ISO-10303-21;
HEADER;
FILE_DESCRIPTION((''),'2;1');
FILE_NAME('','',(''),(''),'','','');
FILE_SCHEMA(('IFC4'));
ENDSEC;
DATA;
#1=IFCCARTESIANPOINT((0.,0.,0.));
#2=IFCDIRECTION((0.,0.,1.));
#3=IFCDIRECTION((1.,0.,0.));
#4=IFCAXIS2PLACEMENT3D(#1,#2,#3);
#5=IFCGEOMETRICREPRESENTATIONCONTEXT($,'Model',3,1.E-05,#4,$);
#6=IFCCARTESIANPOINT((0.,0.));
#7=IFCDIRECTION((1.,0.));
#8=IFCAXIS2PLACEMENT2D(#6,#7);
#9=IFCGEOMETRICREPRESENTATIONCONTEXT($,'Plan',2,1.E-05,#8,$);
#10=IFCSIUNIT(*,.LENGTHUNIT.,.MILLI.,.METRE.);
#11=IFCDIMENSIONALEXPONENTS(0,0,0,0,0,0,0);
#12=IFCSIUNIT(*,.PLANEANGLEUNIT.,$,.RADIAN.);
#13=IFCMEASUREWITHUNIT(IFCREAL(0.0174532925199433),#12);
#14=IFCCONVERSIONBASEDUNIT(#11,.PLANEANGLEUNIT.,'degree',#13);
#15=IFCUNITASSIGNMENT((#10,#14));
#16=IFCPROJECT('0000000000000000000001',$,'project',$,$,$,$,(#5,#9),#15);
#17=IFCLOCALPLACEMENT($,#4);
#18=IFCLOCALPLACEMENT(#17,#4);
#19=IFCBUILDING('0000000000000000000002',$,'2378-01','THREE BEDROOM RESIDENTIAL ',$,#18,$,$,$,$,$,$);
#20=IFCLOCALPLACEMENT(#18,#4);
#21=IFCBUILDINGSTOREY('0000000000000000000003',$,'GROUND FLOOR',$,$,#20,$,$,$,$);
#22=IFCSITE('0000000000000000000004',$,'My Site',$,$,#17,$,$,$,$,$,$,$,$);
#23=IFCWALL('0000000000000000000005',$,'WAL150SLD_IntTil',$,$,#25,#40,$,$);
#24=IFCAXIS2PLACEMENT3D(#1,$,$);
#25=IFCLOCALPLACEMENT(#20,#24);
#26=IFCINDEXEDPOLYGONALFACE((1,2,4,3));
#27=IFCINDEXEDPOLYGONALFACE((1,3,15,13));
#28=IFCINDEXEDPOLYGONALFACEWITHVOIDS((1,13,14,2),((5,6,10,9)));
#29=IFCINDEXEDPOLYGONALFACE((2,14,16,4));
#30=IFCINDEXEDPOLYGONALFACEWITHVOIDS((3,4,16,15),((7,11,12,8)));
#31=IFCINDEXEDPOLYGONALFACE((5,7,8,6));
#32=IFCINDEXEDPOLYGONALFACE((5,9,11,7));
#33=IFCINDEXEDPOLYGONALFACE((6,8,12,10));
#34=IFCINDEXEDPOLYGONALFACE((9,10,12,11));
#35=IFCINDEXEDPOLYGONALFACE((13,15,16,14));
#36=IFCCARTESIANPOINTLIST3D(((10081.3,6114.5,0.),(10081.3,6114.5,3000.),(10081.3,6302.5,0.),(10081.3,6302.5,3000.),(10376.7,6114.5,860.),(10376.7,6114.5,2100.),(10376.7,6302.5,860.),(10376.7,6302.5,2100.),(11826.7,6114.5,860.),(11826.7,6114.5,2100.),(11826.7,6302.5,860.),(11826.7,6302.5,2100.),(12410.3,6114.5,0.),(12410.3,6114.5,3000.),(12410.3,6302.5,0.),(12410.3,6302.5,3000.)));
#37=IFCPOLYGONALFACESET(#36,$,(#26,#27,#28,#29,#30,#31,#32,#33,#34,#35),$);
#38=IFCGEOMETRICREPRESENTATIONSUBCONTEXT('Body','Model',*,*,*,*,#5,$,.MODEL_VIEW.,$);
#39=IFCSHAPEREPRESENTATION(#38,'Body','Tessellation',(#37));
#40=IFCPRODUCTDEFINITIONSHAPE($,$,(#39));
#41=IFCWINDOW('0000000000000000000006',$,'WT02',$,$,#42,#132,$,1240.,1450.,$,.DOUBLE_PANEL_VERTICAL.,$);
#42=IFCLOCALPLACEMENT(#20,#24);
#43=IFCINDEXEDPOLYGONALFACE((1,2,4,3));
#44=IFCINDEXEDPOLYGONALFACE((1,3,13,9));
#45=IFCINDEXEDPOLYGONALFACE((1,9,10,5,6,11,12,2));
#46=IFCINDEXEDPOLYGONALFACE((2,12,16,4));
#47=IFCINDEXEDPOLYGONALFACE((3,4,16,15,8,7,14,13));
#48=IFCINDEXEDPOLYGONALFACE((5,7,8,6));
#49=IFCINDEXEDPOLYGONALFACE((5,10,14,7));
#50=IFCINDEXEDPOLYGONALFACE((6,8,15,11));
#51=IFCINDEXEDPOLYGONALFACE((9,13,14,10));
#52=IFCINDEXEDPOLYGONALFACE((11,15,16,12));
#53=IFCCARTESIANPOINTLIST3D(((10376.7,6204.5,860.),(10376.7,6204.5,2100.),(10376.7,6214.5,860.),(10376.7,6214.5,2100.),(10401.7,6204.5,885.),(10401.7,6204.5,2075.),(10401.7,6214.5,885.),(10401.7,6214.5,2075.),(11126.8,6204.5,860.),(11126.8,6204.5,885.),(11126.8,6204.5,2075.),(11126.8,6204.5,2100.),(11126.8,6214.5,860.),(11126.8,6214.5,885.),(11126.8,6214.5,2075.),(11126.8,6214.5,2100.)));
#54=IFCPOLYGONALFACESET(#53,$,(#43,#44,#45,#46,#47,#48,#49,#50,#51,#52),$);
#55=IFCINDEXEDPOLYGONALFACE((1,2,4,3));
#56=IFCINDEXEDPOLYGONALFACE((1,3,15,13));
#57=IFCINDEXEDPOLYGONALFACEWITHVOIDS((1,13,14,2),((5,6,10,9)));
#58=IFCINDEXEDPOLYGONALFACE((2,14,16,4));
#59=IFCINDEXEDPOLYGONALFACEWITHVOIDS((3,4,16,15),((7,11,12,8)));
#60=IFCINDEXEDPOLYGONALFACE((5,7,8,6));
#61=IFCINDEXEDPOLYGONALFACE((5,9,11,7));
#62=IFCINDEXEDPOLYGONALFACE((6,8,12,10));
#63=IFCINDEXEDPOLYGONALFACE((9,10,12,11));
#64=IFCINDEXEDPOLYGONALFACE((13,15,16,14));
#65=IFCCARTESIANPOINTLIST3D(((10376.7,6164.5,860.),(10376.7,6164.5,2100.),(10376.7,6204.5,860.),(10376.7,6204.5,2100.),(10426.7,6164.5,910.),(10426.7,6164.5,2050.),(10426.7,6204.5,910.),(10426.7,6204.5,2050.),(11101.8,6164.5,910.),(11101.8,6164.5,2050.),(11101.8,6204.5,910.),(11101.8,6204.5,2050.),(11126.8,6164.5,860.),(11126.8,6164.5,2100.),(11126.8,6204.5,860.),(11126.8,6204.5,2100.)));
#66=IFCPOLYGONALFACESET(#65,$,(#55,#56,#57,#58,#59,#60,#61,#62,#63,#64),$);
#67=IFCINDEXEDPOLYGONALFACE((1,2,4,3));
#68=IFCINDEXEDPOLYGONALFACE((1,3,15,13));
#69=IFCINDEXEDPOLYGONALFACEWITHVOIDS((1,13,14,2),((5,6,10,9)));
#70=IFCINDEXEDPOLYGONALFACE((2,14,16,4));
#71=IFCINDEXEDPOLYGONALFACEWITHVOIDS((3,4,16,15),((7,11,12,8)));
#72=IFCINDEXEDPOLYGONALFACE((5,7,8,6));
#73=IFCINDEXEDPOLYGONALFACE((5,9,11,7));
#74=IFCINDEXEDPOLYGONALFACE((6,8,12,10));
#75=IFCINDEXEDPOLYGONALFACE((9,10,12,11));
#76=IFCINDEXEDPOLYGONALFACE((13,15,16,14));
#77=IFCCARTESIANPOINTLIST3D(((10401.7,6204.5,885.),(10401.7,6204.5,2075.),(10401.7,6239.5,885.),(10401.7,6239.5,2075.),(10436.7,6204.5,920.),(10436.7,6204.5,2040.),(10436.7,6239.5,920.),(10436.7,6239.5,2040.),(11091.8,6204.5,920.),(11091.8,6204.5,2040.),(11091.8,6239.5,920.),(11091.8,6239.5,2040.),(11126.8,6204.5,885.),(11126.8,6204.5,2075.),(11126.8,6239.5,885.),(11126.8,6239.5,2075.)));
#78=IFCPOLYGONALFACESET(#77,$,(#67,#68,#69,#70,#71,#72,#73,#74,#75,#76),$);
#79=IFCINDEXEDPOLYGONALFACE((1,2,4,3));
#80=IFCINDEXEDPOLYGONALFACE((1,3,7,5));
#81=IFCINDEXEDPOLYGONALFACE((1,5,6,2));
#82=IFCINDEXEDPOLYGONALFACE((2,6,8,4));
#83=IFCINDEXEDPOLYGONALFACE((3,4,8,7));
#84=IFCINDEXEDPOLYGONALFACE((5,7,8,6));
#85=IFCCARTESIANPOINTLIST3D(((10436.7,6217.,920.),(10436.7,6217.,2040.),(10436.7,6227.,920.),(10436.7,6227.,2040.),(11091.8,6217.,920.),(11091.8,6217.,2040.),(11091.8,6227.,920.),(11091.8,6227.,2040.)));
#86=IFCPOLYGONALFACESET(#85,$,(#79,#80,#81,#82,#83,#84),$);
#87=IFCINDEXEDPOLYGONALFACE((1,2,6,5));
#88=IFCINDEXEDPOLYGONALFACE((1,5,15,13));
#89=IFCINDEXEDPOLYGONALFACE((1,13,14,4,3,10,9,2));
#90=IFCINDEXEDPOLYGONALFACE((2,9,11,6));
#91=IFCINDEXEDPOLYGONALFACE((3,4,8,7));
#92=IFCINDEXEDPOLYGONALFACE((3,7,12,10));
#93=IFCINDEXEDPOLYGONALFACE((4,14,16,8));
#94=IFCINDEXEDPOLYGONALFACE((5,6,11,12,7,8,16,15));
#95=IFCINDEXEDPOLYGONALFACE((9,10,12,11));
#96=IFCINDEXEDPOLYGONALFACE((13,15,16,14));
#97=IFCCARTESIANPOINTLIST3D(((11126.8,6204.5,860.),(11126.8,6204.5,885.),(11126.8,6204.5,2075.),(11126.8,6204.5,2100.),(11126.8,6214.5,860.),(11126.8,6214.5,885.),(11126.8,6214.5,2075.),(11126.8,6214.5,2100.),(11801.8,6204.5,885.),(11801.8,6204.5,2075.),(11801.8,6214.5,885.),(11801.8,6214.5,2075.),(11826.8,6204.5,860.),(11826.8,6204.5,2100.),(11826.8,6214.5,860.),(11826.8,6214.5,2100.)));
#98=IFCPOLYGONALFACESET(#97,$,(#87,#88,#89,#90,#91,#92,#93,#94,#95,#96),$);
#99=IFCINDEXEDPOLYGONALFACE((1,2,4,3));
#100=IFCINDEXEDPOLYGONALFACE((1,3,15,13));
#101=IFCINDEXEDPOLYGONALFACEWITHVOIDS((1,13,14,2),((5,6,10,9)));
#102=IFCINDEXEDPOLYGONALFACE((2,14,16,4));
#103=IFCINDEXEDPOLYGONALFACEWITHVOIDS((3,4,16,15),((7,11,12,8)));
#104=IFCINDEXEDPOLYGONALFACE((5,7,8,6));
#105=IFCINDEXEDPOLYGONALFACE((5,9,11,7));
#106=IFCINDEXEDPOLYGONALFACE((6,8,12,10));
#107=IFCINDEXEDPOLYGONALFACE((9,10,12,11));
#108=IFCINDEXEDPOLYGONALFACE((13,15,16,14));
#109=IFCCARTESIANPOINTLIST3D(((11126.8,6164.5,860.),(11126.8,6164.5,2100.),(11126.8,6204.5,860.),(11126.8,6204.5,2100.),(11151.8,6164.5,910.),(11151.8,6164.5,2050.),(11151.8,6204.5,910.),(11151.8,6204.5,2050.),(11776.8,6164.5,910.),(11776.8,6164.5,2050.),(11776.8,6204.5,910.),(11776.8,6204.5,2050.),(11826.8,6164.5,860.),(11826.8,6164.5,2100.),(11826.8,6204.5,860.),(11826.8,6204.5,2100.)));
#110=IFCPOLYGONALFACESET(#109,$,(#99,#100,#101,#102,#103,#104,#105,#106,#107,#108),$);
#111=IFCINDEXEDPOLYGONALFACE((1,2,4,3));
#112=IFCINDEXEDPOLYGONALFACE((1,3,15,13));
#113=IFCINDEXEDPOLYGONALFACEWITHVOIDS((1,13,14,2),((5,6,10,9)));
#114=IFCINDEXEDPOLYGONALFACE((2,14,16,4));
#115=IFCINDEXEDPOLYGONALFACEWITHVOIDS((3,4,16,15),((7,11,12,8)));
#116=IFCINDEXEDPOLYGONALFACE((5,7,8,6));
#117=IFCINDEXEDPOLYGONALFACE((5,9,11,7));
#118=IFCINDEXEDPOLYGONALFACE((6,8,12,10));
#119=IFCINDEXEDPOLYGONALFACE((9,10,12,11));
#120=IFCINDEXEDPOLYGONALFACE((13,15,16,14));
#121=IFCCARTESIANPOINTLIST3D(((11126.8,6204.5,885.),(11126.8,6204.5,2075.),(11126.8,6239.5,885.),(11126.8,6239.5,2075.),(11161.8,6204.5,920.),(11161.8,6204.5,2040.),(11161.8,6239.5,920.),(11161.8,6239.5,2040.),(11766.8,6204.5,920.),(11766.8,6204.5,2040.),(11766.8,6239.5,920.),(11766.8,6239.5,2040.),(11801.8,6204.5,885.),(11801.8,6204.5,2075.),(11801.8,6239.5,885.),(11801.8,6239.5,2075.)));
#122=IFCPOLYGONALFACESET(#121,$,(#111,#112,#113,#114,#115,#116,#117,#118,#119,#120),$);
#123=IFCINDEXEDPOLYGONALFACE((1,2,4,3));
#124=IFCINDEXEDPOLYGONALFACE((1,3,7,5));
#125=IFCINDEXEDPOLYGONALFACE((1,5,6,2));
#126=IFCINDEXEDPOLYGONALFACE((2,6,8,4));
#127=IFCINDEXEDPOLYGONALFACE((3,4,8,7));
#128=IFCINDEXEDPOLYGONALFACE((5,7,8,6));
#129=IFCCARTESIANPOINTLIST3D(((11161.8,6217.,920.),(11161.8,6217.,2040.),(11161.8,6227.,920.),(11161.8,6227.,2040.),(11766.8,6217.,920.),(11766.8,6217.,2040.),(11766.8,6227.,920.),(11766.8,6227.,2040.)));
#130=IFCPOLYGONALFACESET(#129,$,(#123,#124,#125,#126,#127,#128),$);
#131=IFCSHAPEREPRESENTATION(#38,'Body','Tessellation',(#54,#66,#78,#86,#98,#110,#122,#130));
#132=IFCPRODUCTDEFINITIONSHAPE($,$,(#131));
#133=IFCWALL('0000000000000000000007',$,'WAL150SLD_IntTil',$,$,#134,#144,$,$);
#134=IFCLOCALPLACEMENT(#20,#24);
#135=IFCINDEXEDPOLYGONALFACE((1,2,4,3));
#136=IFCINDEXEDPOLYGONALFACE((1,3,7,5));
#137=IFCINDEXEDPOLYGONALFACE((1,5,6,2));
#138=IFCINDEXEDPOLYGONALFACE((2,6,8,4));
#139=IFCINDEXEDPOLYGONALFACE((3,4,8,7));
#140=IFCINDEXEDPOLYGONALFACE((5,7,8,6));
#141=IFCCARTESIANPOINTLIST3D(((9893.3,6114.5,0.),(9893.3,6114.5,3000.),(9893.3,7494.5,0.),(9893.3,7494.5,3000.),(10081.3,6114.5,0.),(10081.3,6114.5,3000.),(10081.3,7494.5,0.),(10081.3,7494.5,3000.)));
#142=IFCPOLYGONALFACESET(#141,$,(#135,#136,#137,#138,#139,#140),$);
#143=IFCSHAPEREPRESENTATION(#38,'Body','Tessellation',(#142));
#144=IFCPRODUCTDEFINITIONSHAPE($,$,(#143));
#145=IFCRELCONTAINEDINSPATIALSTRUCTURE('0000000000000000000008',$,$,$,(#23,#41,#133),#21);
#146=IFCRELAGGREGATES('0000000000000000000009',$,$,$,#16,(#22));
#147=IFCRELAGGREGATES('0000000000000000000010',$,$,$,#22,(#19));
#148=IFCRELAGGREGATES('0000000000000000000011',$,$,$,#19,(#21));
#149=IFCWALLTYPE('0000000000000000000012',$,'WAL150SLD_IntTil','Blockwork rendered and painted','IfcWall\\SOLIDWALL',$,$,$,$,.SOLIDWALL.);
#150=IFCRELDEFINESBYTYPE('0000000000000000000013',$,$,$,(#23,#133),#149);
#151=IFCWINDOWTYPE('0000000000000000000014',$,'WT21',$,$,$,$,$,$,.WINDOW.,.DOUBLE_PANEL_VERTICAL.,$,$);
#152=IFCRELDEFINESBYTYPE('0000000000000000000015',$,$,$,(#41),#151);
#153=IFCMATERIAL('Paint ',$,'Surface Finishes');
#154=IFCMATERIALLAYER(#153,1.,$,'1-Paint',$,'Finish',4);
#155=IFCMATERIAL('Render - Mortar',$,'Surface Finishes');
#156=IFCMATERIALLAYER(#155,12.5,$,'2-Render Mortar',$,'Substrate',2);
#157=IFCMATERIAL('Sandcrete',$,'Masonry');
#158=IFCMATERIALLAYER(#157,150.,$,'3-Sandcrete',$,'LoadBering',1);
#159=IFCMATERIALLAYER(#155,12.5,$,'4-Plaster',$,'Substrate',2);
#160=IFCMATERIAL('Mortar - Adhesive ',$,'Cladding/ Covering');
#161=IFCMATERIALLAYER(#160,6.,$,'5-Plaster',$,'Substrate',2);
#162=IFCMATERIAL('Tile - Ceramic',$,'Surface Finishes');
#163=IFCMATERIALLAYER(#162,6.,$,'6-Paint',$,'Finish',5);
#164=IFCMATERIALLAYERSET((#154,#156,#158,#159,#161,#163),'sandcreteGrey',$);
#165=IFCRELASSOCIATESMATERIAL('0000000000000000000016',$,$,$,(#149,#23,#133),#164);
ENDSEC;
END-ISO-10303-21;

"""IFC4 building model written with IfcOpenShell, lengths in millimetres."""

from ifc_helpers import new_model, entity, si_unit, converted_unit, frame, origin_with_axes, origin_2d_with_axis, place, context, subcontext, project, spatial, line, indexed_curve, outline, extrude, shape, source, transform, mapped, material, layer, layer_set, layer_usage, type_object, type_shapes, element, fill, save


model = new_model("IFC4")

# Units and contexts
model_context = context("Model", 3, precision=1e-05, world=origin_with_axes())
plan_context = context("Plan", 2, precision=1e-05, world=origin_2d_with_axis())
body_context_1 = subcontext(model_context, "Body", "Model", "MODEL_VIEW")
body_context_2 = subcontext(plan_context, "Body", "Plan", "PLAN_VIEW")
ifc_project = project(units=[si_unit("LENGTHUNIT", "METRE", prefix="MILLI"), converted_unit("PLANEANGLEUNIT", "degree", entity("IfcReal", 0.0174532925199433), si_unit("PLANEANGLEUNIT", "RADIAN"), dimensions=[0, 0, 0, 0, 0, 0, 0])], contexts=[model_context, plan_context])

# Site, building, storey
site_placement = place(None, origin_with_axes())
site = spatial("IfcSite", under=ifc_project, at=site_placement, Name="My Site")
building_placement = place(site_placement, origin_with_axes())
building = spatial("IfcBuilding", under=site, at=building_placement, Name="2378-01", Description="THREE BEDROOM RESIDENTIAL ")
storey_placement = place(building_placement, origin_with_axes())
storey = spatial("IfcBuildingStorey", under=building, at=storey_placement, Name="GROUND FLOOR")

# Shared definitions
shared_shape_1 = source(origin_with_axes(), body_context_1, "Body", "SweptSolid", [
    extrude(outline(indexed_curve([(0.0, 0.0), (1450.0, 0.0), (1450.0, 1240.0), (0.0, 1240.0)], segments=[line(1, 2, 3, 4, 1)])), frame((0.0, -100.0, 0.0), z_axis=(0.0, -1.0, 0.0), x_axis=(1.0, 0.0, 0.0)), (0.0, 0.0, -1.0), 388.0),
])
window_type_1 = type_object("IfcWindowType", Name="WT21", PartitioningType="DOUBLE_PANEL_VERTICAL", PredefinedType="WINDOW")
shared_shape_2 = source(origin_with_axes(), body_context_1, "Body", "SweptSolid", [
    extrude(outline(indexed_curve([(750.0, 0.0), (0.0, 0.0), (0.0, 1240.0), (750.0, 1240.0), (750.0, 1215.0), (25.0, 1215.0), (25.0, 25.0), (750.0, 25.0)], segments=[line(1, 2, 3, 4, 5, 6, 7, 8, 1)])), frame((0.0, 90.0, 0.0), z_axis=(0.0, -1.0, 0.0), x_axis=(1.0, 0.0, 0.0)), (0.0, 0.0, -1.0), 10.0),
    extrude(outline(indexed_curve([(0.0, 0.0), (750.0, 0.0), (750.0, 1240.0), (0.0, 1240.0)], segments=[line(1, 2, 3, 4, 1)]), holes=[indexed_curve([(50.0, 50.0), (725.0, 50.0), (725.0, 1190.0), (50.0, 1190.0)], segments=[line(1, 2, 3, 4, 1)])]), frame((0.0, 50.0, 0.0), z_axis=(0.0, -1.0, 0.0), x_axis=(1.0, 0.0, 0.0)), (0.0, 0.0, -1.0), 40.0),
    extrude(outline(indexed_curve([(0.0, 0.0), (725.0, 0.0), (725.0, 1190.0), (0.0, 1190.0)], segments=[line(1, 2, 3, 4, 1)]), holes=[indexed_curve([(35.0, 35.0), (690.0, 35.0), (690.0, 1155.0), (35.0, 1155.0)], segments=[line(1, 2, 3, 4, 1)])]), frame((25.0, 90.0, 25.0), z_axis=(0.0, -1.0, 0.0), x_axis=(1.0, 0.0, 0.0)), (0.0, 0.0, -1.0), 35.0),
    extrude(outline(indexed_curve([(35.0, 35.0), (690.0, 35.0), (690.0, 1155.0), (35.0, 1155.0)], segments=[line(1, 2, 3, 4, 1)])), frame((25.0, 102.5, 25.0), z_axis=(0.0, -1.0, 0.0), x_axis=(1.0, 0.0, 0.0)), (0.0, 0.0, -1.0), 10.0),
    extrude(outline(indexed_curve([(0.0, 1240.0), (700.0, 1240.0), (700.0, 0.0), (0.0, 0.0), (0.0, 25.0), (675.0, 25.0), (675.0, 1215.0), (0.0, 1215.0)], segments=[line(1, 2, 3, 4, 5, 6, 7, 8, 1)])), frame((750.0, 90.0, 0.0), z_axis=(0.0, -1.0, 0.0), x_axis=(1.0, 0.0, 0.0)), (0.0, 0.0, -1.0), 10.0),
    extrude(outline(indexed_curve([(0.0, 0.0), (700.0, 0.0), (700.0, 1240.0), (0.0, 1240.0)], segments=[line(1, 2, 3, 4, 1)]), holes=[indexed_curve([(25.0, 50.0), (650.0, 50.0), (650.0, 1190.0), (25.0, 1190.0)], segments=[line(1, 2, 3, 4, 1)])]), frame((750.0, 50.0, 0.0), z_axis=(0.0, -1.0, 0.0), x_axis=(1.0, 0.0, 0.0)), (0.0, 0.0, -1.0), 40.0),
    extrude(outline(indexed_curve([(0.0, 0.0), (675.0, 0.0), (675.0, 1190.0), (0.0, 1190.0)], segments=[line(1, 2, 3, 4, 1)]), holes=[indexed_curve([(35.0, 35.0), (640.0, 35.0), (640.0, 1155.0), (35.0, 1155.0)], segments=[line(1, 2, 3, 4, 1)])]), frame((750.0, 90.0, 25.0), z_axis=(0.0, -1.0, 0.0), x_axis=(1.0, 0.0, 0.0)), (0.0, 0.0, -1.0), 35.0),
    extrude(outline(indexed_curve([(35.0, 35.0), (640.0, 35.0), (640.0, 1155.0), (35.0, 1155.0)], segments=[line(1, 2, 3, 4, 1)])), frame((750.0, 102.5, 25.0), z_axis=(0.0, -1.0, 0.0), x_axis=(1.0, 0.0, 0.0)), (0.0, 0.0, -1.0), 10.0),
])
shared_shape_3 = source(origin_with_axes(), body_context_2, "Body", "Curve2D", [
    entity("IfcIndexedPolyCurve", entity("IfcCartesianPointList2D", [[50.0, 50.0], [725.0, 50.0]])),
    entity("IfcIndexedPolyCurve", entity("IfcCartesianPointList2D", [[0.0, 100.0], [25.0, 100.0], [25.0, 90.0], [50.0, 90.0], [50.0, 50.0], [0.0, 50.0]]), [entity("IfcLineIndex", [1, 2, 3, 4, 5, 6, 1])]),
    entity("IfcIndexedPolyCurve", entity("IfcCartesianPointList2D", [[750.0, 100.0], [750.0, 100.0], [750.0, 90.0], [725.0, 90.0], [725.0, 50.0], [750.0, 50.0]])),
    entity("IfcIndexedPolyCurve", entity("IfcCartesianPointList2D", [[25.0, 90.0], [60.0, 90.0], [60.0, 125.0], [25.0, 125.0]]), [entity("IfcLineIndex", [1, 2, 3, 4, 1])]),
    entity("IfcIndexedPolyCurve", entity("IfcCartesianPointList2D", [[750.0, 90.0], [715.0, 90.0], [715.0, 125.0], [750.0, 125.0]]), [entity("IfcLineIndex", [1, 2, 3, 4, 1])]),
    entity("IfcIndexedPolyCurve", entity("IfcCartesianPointList2D", [[60.0, 90.0], [715.0, 90.0]])),
    entity("IfcIndexedPolyCurve", entity("IfcCartesianPointList2D", [[60.0, 125.0], [715.0, 125.0]])),
    entity("IfcIndexedPolyCurve", entity("IfcCartesianPointList2D", [[60.0, 107.5], [715.0, 107.5]])),
    entity("IfcIndexedPolyCurve", entity("IfcCartesianPointList2D", [[775.0, 50.0], [1400.0, 50.0]])),
    entity("IfcIndexedPolyCurve", entity("IfcCartesianPointList2D", [[750.0, 100.0], [750.0, 100.0], [750.0, 90.0], [775.0, 90.0], [775.0, 50.0], [750.0, 50.0]])),
    entity("IfcIndexedPolyCurve", entity("IfcCartesianPointList2D", [[1450.0, 100.0], [1425.0, 100.0], [1425.0, 90.0], [1400.0, 90.0], [1400.0, 50.0], [1450.0, 50.0]]), [entity("IfcLineIndex", [1, 2, 3, 4, 5, 6, 1])]),
    entity("IfcIndexedPolyCurve", entity("IfcCartesianPointList2D", [[750.0, 90.0], [785.0, 90.0], [785.0, 125.0], [750.0, 125.0]]), [entity("IfcLineIndex", [1, 2, 3, 4, 1])]),
    entity("IfcIndexedPolyCurve", entity("IfcCartesianPointList2D", [[1425.0, 90.0], [1390.0, 90.0], [1390.0, 125.0], [1425.0, 125.0]]), [entity("IfcLineIndex", [1, 2, 3, 4, 1])]),
    entity("IfcIndexedPolyCurve", entity("IfcCartesianPointList2D", [[785.0, 90.0], [1390.0, 90.0]])),
    entity("IfcIndexedPolyCurve", entity("IfcCartesianPointList2D", [[785.0, 125.0], [1390.0, 125.0]])),
    entity("IfcIndexedPolyCurve", entity("IfcCartesianPointList2D", [[785.0, 107.5], [1390.0, 107.5]])),
])
type_shapes(window_type_1, [shared_shape_2, shared_shape_3])

# Shared definitions
ifc_material_1 = material(Name="Tile - Ceramic", Category="Surface Finishes")
ifc_material_2 = material(Name="Mortar - Adhesive ", Category="Cladding/ Covering")
ifc_material_3 = material(Name="Render - Mortar", Category="Surface Finishes")
ifc_material_4 = material(Name="Sandcrete", Category="Masonry")

# Wall, opening, window
ifc_material_5 = material(Name="Paint ", Category="Surface Finishes")
ifc_layer_1 = layer(ifc_material_5, 1.0, Name="1-Paint", Category="Finish", Priority=4)
ifc_layer_2 = layer(ifc_material_3, 12.5, Name="2-Render Mortar", Category="Substrate", Priority=2)
ifc_layer_3 = layer(ifc_material_4, 150.0, Name="3-Sandcrete", Category="LoadBering", Priority=1)
ifc_layer_4 = layer(ifc_material_3, 12.5, Name="4-Plaster", Category="Substrate", Priority=2)
ifc_layer_5 = layer(ifc_material_2, 6.0, Name="5-Plaster", Category="Substrate", Priority=2)
ifc_layer_6 = layer(ifc_material_1, 6.0, Name="6-Paint", Category="Finish", Priority=5)
ifc_layer_set_1 = layer_set([ifc_layer_1, ifc_layer_2, ifc_layer_3, ifc_layer_4, ifc_layer_5, ifc_layer_6], Name="sandcreteGrey")
ifc_layer_usage_1 = layer_usage(ifc_layer_set_1, "AXIS2", "POSITIVE", 0.0)
wall_type_1 = type_object("IfcWallType", Name="WAL150SLD_IntTil", Description="Blockwork rendered and painted", ApplicableOccurrence="IfcWall\\SOLIDWALL", PredefinedType="SOLIDWALL", material=ifc_layer_set_1)
wall_1_placement = place(storey_placement, frame((10081.3, 6114.5, 0.0), z_axis=(0.0, 0.0, 1.0), x_axis=(1.0, 0.0, 0.0)))
wall_1 = element("IfcWall", 1, at=wall_1_placement, inside=storey, type_object=wall_type_1, material=ifc_layer_usage_1, Name="WAL150SLD_IntTil", context=body_context_1, shape_type="SweptSolid", body=[
    extrude(outline(indexed_curve([(0.0, 0.0), (0.0, 188.0), (2329.0, 188.0), (2329.0, 0.0), (0.0, 0.0)], self_intersect=False)), origin_with_axes(), (0.0, 0.0, 1.0), 3000.0),
])
opening_1_placement = place(wall_1_placement, frame((295.5, 0.0, 860.0), z_axis=(0.0, 0.0, 1.0), x_axis=(1.0, 0.0, 0.0)))
opening_1 = element("IfcOpeningElement", 2, at=opening_1_placement, cuts=wall_1, PredefinedType="OPENING", context=body_context_1, shape_type="MappedRepresentation", body=[
    mapped(shared_shape_1, transform((0.0, 0.0, 0.0), x_axis=(1.0, 0.0, 0.0), y_axis=(0.0, 1.0, 0.0), z_axis=(0.0, 0.0, 1.0), scale=1.0)),
])
window_1_placement = place(opening_1_placement, frame((0.0, 0.0, 0.0), z_axis=(0.0, 0.0, 1.0), x_axis=(1.0, 0.0, 0.0)))
window_1 = element("IfcWindow", 3, at=window_1_placement, inside=storey, type_object=window_type_1, Name="WT02", OverallHeight=1240.0, OverallWidth=1450.0, PartitioningType="DOUBLE_PANEL_VERTICAL", shapes=[
    shape(body_context_1, "Body", "MappedRepresentation", [mapped(shared_shape_2, transform((0.0, 0.0, 0.0), x_axis=(1.0, 0.0, 0.0), y_axis=(0.0, 1.0, 0.0), z_axis=(0.0, 0.0, 1.0), scale=1.0))]),
    shape(body_context_2, "Body", "MappedRepresentation", [mapped(shared_shape_3, transform((0.0, 0.0, 0.0), x_axis=(1.0, 0.0, 0.0), y_axis=(0.0, 1.0, 0.0), z_axis=(0.0, 0.0, 1.0), scale=1.0))]),
])
fill(opening_1, window_1)

# Wall
ifc_layer_usage_2 = layer_usage(ifc_layer_set_1, "AXIS2", "POSITIVE", 0.0)
wall_2_placement = place(storey_placement, frame((9893.3, 7494.5, 0.0), z_axis=(0.0, 0.0, 1.0), x_axis=(-0.000001, -1.0, 0.0)))
element("IfcWall", 4, at=wall_2_placement, inside=storey, type_object=wall_type_1, material=ifc_layer_usage_2, Name="WAL150SLD_IntTil", context=body_context_1, shape_type="SweptSolid", body=[
    extrude(outline(indexed_curve([(0.0, 0.0), (0.0, 188.0), (1380.0, 188.0), (1380.0, 0.0), (0.0, 0.0)], self_intersect=False)), origin_with_axes(), (0.0, 0.0, 1.0), 3000.0),
])

save(model, "model.ifc")
